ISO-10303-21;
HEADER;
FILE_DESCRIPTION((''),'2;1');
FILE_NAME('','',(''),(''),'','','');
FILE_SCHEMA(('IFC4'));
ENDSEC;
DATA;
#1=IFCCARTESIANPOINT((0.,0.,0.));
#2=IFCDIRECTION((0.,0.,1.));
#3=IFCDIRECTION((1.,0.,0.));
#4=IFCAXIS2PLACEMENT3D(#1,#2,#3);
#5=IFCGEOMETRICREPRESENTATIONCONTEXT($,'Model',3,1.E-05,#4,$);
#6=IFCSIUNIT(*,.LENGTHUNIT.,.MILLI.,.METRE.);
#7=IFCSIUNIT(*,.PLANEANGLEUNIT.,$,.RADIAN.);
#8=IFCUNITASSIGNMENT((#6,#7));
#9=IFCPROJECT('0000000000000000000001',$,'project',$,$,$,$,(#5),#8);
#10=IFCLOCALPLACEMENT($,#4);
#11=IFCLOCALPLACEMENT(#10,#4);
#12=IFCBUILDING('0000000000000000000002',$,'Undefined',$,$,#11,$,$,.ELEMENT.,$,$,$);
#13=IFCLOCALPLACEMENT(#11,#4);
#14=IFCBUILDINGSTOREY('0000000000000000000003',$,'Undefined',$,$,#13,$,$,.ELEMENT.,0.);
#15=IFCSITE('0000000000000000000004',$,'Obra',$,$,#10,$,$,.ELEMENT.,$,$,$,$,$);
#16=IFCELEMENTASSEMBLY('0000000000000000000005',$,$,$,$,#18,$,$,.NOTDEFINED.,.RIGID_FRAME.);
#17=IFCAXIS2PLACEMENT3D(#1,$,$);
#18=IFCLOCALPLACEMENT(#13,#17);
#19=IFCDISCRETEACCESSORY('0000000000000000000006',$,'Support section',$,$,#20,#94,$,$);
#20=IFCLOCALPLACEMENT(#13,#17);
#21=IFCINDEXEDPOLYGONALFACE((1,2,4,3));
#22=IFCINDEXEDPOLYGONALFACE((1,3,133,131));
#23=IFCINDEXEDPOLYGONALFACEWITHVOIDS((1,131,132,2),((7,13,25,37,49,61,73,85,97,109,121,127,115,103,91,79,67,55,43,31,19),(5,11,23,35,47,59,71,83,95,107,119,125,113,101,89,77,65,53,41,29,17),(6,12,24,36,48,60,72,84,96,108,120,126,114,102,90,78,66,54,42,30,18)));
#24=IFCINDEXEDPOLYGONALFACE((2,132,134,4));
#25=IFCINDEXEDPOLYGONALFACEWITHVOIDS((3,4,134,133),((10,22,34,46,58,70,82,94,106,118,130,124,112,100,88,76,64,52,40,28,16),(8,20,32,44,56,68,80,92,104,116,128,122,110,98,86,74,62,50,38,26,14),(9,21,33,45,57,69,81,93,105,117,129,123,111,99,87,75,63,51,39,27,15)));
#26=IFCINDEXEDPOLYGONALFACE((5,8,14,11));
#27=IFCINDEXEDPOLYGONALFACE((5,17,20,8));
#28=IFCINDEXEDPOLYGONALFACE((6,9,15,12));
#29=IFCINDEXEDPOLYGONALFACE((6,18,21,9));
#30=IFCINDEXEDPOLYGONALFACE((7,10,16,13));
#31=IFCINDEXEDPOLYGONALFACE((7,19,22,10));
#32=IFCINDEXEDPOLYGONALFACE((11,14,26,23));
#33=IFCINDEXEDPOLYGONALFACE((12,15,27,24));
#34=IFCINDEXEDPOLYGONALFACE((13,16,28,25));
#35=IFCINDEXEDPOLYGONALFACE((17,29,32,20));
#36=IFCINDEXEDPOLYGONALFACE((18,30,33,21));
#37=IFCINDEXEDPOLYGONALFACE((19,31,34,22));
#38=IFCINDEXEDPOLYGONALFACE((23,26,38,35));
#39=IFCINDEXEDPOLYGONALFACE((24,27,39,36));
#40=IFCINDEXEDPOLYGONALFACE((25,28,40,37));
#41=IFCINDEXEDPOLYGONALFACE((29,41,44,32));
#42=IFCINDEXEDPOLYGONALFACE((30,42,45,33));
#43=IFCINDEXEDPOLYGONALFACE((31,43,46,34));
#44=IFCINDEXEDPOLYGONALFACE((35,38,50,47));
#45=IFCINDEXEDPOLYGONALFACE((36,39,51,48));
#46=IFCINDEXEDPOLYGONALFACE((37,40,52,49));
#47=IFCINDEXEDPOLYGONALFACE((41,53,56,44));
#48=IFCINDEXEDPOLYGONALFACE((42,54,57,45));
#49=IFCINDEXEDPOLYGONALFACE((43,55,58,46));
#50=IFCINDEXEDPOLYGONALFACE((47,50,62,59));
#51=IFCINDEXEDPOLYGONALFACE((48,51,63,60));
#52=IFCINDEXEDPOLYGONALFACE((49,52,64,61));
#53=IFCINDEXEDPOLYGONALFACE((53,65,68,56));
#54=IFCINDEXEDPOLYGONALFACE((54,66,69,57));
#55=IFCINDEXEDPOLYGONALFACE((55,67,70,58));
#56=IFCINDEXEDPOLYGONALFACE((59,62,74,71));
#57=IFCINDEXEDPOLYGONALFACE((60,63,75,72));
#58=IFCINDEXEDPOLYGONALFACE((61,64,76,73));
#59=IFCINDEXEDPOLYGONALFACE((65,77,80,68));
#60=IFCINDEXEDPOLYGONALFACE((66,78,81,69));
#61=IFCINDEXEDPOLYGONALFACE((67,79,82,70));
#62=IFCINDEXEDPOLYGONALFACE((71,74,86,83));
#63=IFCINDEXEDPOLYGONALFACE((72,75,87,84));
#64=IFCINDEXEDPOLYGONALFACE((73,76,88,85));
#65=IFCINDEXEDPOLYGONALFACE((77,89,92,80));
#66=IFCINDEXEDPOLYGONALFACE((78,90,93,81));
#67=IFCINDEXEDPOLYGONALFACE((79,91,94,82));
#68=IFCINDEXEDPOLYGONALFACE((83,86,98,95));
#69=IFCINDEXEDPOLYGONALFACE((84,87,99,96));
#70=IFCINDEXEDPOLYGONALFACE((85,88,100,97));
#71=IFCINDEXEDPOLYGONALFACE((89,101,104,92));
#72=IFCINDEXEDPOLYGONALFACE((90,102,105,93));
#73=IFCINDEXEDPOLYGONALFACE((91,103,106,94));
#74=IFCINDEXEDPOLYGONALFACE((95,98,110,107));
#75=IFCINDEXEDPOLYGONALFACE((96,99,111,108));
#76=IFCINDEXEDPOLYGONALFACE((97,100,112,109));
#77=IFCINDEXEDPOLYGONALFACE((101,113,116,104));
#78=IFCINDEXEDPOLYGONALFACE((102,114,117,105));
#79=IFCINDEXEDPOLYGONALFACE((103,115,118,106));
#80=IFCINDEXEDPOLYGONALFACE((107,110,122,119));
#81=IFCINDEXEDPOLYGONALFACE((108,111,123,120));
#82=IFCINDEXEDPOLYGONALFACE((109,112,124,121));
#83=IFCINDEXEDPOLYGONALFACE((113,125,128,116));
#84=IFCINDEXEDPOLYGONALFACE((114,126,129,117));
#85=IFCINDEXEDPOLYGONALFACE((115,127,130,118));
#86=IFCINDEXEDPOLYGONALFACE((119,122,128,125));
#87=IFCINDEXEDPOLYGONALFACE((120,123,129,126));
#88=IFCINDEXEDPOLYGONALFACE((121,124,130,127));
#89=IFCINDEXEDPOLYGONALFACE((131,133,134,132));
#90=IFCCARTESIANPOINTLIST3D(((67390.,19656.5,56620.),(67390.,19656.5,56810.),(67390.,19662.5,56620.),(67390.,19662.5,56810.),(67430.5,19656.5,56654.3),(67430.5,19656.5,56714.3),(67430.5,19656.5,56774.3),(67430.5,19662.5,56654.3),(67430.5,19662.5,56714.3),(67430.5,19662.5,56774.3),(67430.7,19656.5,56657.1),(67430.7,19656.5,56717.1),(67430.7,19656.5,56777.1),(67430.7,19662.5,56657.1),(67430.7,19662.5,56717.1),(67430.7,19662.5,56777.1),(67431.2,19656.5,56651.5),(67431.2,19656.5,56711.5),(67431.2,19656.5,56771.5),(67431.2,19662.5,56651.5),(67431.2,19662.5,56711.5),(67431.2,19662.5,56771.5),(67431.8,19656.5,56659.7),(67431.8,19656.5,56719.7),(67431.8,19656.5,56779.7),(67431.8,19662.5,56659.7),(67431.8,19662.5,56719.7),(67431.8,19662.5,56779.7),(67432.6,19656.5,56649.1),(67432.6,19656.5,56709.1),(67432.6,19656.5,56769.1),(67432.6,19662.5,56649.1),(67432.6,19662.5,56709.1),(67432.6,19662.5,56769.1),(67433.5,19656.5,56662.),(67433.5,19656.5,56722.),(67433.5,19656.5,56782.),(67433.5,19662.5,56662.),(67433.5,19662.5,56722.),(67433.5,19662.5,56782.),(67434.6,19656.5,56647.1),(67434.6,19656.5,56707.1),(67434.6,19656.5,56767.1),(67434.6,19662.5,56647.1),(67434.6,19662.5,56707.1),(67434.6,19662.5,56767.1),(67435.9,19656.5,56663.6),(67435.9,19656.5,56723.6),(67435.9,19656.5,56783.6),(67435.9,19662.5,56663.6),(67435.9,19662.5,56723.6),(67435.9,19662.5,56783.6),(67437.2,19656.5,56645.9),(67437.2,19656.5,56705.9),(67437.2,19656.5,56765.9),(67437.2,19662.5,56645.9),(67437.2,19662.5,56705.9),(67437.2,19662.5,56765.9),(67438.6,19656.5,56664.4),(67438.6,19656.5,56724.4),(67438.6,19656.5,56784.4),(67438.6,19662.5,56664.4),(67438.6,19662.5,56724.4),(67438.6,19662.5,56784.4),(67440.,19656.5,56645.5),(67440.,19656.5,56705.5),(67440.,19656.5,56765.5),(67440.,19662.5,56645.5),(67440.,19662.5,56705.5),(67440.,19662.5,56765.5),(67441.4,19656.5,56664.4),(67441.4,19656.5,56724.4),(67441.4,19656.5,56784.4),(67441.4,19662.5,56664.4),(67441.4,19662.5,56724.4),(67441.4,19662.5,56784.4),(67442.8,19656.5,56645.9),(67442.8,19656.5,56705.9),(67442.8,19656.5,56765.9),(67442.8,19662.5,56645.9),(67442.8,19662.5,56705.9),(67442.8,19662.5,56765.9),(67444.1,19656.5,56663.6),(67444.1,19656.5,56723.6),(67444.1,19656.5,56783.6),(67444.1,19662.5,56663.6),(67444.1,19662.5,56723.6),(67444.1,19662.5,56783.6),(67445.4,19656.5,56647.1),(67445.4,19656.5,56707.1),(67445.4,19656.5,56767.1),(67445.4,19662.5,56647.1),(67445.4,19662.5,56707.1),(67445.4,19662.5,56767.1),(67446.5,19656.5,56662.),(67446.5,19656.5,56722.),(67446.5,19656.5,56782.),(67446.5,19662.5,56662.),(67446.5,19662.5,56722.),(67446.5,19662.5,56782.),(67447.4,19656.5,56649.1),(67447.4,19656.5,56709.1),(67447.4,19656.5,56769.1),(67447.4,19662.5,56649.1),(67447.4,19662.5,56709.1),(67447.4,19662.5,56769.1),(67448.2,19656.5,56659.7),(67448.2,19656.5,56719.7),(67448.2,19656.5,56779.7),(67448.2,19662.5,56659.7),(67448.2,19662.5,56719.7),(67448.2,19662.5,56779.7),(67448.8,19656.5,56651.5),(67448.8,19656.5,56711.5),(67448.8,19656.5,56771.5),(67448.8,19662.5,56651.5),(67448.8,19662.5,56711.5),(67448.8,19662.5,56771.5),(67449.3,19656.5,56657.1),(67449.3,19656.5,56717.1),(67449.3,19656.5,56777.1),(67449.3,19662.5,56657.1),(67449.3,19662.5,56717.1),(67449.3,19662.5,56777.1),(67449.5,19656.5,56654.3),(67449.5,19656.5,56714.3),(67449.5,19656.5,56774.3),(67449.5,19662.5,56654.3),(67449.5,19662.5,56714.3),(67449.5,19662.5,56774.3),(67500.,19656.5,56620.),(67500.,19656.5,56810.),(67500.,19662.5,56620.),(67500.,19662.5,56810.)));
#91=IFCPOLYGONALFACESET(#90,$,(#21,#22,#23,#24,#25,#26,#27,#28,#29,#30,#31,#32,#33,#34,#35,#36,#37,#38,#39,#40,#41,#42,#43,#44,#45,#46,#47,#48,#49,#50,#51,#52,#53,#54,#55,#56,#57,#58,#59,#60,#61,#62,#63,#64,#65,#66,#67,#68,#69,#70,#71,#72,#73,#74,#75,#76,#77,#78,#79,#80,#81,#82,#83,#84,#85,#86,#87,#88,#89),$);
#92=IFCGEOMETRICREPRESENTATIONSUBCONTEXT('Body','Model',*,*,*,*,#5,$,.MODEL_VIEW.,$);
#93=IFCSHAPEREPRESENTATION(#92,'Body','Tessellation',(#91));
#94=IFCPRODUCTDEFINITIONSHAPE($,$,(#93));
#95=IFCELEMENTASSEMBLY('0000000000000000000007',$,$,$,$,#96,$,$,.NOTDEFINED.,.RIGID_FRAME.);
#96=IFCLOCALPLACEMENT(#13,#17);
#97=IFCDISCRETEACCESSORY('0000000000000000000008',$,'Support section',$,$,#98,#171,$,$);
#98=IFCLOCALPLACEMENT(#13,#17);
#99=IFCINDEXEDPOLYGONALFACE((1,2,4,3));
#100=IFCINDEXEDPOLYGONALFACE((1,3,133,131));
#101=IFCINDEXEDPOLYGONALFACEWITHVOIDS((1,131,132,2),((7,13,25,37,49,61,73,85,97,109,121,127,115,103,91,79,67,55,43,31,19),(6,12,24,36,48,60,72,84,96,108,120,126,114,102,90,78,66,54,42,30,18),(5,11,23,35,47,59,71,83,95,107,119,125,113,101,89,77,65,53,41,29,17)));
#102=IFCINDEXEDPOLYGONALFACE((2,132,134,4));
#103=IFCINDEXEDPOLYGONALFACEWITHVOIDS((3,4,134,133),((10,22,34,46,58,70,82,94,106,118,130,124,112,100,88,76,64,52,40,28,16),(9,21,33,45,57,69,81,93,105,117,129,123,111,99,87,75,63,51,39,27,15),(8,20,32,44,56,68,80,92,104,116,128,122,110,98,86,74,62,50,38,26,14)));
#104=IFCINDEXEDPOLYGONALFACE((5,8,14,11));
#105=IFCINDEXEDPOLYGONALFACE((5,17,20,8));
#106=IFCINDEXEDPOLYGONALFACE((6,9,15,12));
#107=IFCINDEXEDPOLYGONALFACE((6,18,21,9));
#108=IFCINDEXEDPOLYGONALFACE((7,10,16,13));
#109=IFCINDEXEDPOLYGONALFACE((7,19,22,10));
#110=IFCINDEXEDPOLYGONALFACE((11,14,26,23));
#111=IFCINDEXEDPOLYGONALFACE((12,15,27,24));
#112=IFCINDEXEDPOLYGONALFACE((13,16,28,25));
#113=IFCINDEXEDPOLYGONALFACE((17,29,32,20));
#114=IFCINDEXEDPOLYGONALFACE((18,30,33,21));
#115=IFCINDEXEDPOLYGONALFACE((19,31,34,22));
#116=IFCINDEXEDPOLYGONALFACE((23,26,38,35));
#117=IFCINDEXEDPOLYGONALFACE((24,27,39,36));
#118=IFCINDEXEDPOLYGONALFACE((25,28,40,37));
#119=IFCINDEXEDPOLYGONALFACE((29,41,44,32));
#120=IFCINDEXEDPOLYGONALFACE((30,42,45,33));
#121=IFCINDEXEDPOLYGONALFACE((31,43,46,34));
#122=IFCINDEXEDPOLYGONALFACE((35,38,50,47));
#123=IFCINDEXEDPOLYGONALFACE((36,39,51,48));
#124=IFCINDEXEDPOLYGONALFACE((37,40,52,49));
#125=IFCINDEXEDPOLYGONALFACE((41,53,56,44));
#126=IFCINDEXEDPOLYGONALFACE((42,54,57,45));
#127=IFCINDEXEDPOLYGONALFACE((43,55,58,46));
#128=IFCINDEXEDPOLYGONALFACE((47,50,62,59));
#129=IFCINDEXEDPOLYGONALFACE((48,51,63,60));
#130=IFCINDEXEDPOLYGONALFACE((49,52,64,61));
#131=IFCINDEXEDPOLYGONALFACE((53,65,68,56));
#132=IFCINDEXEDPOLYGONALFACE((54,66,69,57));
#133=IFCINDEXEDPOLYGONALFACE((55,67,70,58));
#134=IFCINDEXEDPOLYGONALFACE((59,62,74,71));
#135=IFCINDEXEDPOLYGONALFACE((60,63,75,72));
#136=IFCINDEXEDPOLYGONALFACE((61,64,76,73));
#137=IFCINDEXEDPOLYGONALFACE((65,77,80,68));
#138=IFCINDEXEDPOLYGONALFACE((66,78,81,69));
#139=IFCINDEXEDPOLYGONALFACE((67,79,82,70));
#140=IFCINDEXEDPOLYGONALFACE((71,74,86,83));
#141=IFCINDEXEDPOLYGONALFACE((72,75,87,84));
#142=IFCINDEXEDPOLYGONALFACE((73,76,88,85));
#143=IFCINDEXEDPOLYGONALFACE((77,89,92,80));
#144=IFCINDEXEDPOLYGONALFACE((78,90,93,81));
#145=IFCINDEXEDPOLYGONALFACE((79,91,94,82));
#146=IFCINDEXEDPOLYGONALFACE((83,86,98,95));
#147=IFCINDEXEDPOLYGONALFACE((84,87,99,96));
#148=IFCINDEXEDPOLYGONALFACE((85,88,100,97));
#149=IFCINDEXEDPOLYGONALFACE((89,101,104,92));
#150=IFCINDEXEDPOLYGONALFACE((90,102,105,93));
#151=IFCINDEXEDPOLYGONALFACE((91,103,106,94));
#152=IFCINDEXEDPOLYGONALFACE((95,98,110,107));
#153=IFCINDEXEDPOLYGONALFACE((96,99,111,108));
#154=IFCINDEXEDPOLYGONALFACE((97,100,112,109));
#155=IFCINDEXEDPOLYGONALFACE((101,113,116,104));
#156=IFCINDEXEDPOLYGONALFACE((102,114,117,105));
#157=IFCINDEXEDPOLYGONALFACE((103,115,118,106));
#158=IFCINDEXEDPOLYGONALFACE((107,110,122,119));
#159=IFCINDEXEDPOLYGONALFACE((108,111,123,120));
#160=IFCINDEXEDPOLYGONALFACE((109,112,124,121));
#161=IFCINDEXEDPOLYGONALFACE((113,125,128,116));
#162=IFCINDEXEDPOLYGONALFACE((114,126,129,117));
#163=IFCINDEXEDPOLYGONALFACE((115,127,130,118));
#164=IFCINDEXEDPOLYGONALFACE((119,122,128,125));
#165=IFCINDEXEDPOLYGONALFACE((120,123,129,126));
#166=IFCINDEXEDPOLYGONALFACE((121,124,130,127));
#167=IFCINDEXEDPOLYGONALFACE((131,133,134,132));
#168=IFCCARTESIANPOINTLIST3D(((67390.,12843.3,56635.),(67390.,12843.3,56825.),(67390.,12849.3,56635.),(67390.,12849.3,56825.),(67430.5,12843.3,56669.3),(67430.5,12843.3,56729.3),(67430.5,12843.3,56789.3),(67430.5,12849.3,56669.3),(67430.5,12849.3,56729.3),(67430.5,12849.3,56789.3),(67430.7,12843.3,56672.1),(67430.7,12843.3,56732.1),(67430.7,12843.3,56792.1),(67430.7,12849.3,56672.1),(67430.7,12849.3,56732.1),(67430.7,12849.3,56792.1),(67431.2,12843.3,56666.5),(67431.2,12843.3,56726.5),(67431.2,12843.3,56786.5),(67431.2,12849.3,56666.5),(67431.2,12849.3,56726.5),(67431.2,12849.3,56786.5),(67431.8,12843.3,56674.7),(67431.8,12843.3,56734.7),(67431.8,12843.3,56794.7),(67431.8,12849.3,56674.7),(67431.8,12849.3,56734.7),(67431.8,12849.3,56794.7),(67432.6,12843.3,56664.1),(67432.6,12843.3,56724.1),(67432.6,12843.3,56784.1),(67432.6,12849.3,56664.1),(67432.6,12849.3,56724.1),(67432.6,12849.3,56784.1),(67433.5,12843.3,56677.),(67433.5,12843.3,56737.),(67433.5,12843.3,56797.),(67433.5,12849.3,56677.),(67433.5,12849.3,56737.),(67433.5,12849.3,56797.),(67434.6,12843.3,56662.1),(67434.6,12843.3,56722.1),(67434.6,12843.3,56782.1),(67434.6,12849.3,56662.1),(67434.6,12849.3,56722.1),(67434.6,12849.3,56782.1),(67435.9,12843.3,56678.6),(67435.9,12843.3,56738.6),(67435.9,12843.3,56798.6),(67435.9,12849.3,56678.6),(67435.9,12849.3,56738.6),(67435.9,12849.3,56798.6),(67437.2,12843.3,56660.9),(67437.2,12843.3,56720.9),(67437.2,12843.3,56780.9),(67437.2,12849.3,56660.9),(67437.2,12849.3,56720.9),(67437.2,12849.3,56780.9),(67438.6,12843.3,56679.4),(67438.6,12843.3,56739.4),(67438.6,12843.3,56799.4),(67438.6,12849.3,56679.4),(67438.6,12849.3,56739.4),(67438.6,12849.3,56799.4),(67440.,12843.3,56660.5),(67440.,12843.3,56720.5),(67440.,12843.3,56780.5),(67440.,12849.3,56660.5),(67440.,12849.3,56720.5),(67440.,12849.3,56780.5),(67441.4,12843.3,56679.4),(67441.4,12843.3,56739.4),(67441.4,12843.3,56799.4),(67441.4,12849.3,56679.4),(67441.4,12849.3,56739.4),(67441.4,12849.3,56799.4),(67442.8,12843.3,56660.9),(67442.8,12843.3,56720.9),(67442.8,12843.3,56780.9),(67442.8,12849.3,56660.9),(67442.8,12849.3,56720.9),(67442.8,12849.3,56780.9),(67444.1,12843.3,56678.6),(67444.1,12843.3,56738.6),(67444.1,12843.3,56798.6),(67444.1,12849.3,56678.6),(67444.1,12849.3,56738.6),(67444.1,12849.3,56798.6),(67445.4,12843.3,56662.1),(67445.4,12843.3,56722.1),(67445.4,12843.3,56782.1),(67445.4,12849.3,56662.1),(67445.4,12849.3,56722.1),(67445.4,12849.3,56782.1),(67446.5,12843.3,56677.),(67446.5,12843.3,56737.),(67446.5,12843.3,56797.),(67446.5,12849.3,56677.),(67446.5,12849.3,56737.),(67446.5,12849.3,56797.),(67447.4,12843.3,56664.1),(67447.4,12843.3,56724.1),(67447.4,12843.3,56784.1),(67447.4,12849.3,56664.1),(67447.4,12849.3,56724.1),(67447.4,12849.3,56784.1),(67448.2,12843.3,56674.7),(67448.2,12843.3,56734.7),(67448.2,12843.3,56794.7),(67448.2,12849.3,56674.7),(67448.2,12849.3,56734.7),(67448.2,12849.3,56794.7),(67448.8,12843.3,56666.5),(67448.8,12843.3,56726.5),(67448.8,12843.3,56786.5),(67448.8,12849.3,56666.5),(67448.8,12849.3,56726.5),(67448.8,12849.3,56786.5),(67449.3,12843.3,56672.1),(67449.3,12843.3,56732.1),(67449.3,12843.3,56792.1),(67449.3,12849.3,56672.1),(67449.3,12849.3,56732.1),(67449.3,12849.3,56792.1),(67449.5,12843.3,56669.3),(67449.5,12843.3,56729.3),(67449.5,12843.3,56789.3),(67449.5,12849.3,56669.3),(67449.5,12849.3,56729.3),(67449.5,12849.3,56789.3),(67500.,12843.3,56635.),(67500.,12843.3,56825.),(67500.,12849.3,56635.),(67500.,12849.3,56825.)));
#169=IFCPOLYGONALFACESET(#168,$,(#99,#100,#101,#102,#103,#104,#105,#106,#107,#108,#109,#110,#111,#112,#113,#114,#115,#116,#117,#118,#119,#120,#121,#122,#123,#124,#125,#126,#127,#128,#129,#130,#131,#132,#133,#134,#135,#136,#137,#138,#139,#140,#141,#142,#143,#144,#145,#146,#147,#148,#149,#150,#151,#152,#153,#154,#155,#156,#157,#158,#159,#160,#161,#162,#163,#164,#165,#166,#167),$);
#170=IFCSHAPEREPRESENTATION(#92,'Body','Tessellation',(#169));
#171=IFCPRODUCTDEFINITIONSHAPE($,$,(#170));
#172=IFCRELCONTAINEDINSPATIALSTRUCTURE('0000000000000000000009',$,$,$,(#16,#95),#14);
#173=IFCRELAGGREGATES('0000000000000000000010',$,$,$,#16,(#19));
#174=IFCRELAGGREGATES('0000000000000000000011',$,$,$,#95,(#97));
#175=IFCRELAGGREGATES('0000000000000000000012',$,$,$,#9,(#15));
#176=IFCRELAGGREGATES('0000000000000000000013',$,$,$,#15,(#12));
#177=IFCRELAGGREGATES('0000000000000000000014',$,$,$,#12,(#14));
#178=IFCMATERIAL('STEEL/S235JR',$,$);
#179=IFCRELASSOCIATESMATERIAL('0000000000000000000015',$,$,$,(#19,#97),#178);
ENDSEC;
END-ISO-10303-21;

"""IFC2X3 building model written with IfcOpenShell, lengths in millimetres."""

from ifc_helpers import new_model, si_unit, frame, origin_with_axes, origin_2d_with_axis, place, context, subcontext, project, spatial, rectangle, circle, extrude, source, transform, mapped, material, element, aggregate, save


model = new_model("IFC2X3")

# Units and contexts
model_context = context("Model", 3, precision=1e-05, world=origin_with_axes())
body_context = subcontext(model_context, "Body", "Model", "MODEL_VIEW")
ifc_project = project(units=[si_unit("LENGTHUNIT", "METRE", prefix="MILLI"), si_unit("PLANEANGLEUNIT", "RADIAN")], contexts=[model_context])

# Site, building, storey
site_placement = place(None, origin_with_axes())
site = spatial("IfcSite", under=ifc_project, at=site_placement, Name="Obra", CompositionType="ELEMENT")
building_placement = place(site_placement, origin_with_axes())
building = spatial("IfcBuilding", under=site, at=building_placement, Name="Undefined", CompositionType="ELEMENT")
storey_placement = place(building_placement, origin_with_axes())
storey = spatial("IfcBuildingStorey", under=building, at=storey_placement, Name="Undefined", CompositionType="ELEMENT", Elevation=0.0)

# Shared definitions
ifc_material = material(Name="STEEL/S235JR")

# Element assemblies, discrete accessories, openings
shared_shape_1 = source(origin_with_axes(), body_context, "Body", "SweptSolid", [
    extrude(circle(Radius=9.5, at=origin_2d_with_axis()), frame((0.0, -9.2, 0.0), z_axis=(0.0, 1.0, 0.0), x_axis=(1.0, 0.0, 0.0)), (0.0, 0.0, 1.0), 6.2),
])
assembly_1_placement = place(storey_placement, origin_with_axes())
assembly_1 = element("IfcElementAssembly", 1, at=assembly_1_placement, inside=storey, AssemblyPlace="NOTDEFINED", PredefinedType="RIGID_FRAME")
discrete_accessory_1_placement = place(assembly_1_placement, frame((67445.0, 19659.5, 56620.0), z_axis=(0.0, 0.0, 1.0), x_axis=(1.0, 0.0, 0.0)))
discrete_accessory_1 = element("IfcDiscreteAccessory", 2, at=discrete_accessory_1_placement, material=ifc_material, Name="Support section", context=body_context, shape_type="SweptSolid", body=[
    extrude(rectangle(XDim=6.0, YDim=110.0, at=origin_2d_with_axis()), frame((0.0, 0.0, 190.0), z_axis=(0.0, 0.0, -1.0), x_axis=(0.0, 1.0, 0.0)), (0.0, 0.0, 1.0), 190.0),
])
opening_1_placement = place(assembly_1_placement, frame((67490.0, 19653.4, 56835.0), z_axis=(-1.0, 0.0, 0.0), x_axis=(0.0, 0.0, -1.0)))
element("IfcOpeningElement", 3, at=opening_1_placement, cuts=discrete_accessory_1, ObjectType="Opening", context=body_context, shape_type="MappedRepresentation", body=[
    mapped(shared_shape_1, transform((60.0, 0.0, 50.0))),
    mapped(shared_shape_1, transform((120.0, 0.0, 50.0))),
    mapped(shared_shape_1, transform((180.0, 0.0, 50.0))),
])
aggregate(assembly_1, [discrete_accessory_1])
assembly_2_placement = place(storey_placement, origin_with_axes())
assembly_2 = element("IfcElementAssembly", 4, at=assembly_2_placement, inside=storey, AssemblyPlace="NOTDEFINED", PredefinedType="RIGID_FRAME")
discrete_accessory_2_placement = place(assembly_2_placement, frame((67445.0, 12846.3, 56635.0), z_axis=(0.0, 0.0, 1.0), x_axis=(1.0, 0.0, 0.0)))
discrete_accessory_2 = element("IfcDiscreteAccessory", 5, at=discrete_accessory_2_placement, material=ifc_material, Name="Support section", context=body_context, shape_type="SweptSolid", body=[
    extrude(rectangle(XDim=6.0, YDim=110.0, at=origin_2d_with_axis()), frame((0.0, 0.0, 190.0), z_axis=(0.0, 0.0, -1.0), x_axis=(0.0, 1.0, 0.0)), (0.0, 0.0, 1.0), 190.0),
])
opening_2_placement = place(assembly_2_placement, frame((67490.0, 12840.2, 56850.0), z_axis=(-1.0, 0.0, 0.0), x_axis=(0.0, 0.0, -1.0)))
element("IfcOpeningElement", 6, at=opening_2_placement, cuts=discrete_accessory_2, ObjectType="Opening", context=body_context, shape_type="MappedRepresentation", body=[
    mapped(shared_shape_1, transform((60.0, 0.0, 50.0))),
    mapped(shared_shape_1, transform((120.0, 0.0, 50.0))),
    mapped(shared_shape_1, transform((180.0, 0.0, 50.0))),
])
aggregate(assembly_2, [discrete_accessory_2])

save(model, "model.ifc")
